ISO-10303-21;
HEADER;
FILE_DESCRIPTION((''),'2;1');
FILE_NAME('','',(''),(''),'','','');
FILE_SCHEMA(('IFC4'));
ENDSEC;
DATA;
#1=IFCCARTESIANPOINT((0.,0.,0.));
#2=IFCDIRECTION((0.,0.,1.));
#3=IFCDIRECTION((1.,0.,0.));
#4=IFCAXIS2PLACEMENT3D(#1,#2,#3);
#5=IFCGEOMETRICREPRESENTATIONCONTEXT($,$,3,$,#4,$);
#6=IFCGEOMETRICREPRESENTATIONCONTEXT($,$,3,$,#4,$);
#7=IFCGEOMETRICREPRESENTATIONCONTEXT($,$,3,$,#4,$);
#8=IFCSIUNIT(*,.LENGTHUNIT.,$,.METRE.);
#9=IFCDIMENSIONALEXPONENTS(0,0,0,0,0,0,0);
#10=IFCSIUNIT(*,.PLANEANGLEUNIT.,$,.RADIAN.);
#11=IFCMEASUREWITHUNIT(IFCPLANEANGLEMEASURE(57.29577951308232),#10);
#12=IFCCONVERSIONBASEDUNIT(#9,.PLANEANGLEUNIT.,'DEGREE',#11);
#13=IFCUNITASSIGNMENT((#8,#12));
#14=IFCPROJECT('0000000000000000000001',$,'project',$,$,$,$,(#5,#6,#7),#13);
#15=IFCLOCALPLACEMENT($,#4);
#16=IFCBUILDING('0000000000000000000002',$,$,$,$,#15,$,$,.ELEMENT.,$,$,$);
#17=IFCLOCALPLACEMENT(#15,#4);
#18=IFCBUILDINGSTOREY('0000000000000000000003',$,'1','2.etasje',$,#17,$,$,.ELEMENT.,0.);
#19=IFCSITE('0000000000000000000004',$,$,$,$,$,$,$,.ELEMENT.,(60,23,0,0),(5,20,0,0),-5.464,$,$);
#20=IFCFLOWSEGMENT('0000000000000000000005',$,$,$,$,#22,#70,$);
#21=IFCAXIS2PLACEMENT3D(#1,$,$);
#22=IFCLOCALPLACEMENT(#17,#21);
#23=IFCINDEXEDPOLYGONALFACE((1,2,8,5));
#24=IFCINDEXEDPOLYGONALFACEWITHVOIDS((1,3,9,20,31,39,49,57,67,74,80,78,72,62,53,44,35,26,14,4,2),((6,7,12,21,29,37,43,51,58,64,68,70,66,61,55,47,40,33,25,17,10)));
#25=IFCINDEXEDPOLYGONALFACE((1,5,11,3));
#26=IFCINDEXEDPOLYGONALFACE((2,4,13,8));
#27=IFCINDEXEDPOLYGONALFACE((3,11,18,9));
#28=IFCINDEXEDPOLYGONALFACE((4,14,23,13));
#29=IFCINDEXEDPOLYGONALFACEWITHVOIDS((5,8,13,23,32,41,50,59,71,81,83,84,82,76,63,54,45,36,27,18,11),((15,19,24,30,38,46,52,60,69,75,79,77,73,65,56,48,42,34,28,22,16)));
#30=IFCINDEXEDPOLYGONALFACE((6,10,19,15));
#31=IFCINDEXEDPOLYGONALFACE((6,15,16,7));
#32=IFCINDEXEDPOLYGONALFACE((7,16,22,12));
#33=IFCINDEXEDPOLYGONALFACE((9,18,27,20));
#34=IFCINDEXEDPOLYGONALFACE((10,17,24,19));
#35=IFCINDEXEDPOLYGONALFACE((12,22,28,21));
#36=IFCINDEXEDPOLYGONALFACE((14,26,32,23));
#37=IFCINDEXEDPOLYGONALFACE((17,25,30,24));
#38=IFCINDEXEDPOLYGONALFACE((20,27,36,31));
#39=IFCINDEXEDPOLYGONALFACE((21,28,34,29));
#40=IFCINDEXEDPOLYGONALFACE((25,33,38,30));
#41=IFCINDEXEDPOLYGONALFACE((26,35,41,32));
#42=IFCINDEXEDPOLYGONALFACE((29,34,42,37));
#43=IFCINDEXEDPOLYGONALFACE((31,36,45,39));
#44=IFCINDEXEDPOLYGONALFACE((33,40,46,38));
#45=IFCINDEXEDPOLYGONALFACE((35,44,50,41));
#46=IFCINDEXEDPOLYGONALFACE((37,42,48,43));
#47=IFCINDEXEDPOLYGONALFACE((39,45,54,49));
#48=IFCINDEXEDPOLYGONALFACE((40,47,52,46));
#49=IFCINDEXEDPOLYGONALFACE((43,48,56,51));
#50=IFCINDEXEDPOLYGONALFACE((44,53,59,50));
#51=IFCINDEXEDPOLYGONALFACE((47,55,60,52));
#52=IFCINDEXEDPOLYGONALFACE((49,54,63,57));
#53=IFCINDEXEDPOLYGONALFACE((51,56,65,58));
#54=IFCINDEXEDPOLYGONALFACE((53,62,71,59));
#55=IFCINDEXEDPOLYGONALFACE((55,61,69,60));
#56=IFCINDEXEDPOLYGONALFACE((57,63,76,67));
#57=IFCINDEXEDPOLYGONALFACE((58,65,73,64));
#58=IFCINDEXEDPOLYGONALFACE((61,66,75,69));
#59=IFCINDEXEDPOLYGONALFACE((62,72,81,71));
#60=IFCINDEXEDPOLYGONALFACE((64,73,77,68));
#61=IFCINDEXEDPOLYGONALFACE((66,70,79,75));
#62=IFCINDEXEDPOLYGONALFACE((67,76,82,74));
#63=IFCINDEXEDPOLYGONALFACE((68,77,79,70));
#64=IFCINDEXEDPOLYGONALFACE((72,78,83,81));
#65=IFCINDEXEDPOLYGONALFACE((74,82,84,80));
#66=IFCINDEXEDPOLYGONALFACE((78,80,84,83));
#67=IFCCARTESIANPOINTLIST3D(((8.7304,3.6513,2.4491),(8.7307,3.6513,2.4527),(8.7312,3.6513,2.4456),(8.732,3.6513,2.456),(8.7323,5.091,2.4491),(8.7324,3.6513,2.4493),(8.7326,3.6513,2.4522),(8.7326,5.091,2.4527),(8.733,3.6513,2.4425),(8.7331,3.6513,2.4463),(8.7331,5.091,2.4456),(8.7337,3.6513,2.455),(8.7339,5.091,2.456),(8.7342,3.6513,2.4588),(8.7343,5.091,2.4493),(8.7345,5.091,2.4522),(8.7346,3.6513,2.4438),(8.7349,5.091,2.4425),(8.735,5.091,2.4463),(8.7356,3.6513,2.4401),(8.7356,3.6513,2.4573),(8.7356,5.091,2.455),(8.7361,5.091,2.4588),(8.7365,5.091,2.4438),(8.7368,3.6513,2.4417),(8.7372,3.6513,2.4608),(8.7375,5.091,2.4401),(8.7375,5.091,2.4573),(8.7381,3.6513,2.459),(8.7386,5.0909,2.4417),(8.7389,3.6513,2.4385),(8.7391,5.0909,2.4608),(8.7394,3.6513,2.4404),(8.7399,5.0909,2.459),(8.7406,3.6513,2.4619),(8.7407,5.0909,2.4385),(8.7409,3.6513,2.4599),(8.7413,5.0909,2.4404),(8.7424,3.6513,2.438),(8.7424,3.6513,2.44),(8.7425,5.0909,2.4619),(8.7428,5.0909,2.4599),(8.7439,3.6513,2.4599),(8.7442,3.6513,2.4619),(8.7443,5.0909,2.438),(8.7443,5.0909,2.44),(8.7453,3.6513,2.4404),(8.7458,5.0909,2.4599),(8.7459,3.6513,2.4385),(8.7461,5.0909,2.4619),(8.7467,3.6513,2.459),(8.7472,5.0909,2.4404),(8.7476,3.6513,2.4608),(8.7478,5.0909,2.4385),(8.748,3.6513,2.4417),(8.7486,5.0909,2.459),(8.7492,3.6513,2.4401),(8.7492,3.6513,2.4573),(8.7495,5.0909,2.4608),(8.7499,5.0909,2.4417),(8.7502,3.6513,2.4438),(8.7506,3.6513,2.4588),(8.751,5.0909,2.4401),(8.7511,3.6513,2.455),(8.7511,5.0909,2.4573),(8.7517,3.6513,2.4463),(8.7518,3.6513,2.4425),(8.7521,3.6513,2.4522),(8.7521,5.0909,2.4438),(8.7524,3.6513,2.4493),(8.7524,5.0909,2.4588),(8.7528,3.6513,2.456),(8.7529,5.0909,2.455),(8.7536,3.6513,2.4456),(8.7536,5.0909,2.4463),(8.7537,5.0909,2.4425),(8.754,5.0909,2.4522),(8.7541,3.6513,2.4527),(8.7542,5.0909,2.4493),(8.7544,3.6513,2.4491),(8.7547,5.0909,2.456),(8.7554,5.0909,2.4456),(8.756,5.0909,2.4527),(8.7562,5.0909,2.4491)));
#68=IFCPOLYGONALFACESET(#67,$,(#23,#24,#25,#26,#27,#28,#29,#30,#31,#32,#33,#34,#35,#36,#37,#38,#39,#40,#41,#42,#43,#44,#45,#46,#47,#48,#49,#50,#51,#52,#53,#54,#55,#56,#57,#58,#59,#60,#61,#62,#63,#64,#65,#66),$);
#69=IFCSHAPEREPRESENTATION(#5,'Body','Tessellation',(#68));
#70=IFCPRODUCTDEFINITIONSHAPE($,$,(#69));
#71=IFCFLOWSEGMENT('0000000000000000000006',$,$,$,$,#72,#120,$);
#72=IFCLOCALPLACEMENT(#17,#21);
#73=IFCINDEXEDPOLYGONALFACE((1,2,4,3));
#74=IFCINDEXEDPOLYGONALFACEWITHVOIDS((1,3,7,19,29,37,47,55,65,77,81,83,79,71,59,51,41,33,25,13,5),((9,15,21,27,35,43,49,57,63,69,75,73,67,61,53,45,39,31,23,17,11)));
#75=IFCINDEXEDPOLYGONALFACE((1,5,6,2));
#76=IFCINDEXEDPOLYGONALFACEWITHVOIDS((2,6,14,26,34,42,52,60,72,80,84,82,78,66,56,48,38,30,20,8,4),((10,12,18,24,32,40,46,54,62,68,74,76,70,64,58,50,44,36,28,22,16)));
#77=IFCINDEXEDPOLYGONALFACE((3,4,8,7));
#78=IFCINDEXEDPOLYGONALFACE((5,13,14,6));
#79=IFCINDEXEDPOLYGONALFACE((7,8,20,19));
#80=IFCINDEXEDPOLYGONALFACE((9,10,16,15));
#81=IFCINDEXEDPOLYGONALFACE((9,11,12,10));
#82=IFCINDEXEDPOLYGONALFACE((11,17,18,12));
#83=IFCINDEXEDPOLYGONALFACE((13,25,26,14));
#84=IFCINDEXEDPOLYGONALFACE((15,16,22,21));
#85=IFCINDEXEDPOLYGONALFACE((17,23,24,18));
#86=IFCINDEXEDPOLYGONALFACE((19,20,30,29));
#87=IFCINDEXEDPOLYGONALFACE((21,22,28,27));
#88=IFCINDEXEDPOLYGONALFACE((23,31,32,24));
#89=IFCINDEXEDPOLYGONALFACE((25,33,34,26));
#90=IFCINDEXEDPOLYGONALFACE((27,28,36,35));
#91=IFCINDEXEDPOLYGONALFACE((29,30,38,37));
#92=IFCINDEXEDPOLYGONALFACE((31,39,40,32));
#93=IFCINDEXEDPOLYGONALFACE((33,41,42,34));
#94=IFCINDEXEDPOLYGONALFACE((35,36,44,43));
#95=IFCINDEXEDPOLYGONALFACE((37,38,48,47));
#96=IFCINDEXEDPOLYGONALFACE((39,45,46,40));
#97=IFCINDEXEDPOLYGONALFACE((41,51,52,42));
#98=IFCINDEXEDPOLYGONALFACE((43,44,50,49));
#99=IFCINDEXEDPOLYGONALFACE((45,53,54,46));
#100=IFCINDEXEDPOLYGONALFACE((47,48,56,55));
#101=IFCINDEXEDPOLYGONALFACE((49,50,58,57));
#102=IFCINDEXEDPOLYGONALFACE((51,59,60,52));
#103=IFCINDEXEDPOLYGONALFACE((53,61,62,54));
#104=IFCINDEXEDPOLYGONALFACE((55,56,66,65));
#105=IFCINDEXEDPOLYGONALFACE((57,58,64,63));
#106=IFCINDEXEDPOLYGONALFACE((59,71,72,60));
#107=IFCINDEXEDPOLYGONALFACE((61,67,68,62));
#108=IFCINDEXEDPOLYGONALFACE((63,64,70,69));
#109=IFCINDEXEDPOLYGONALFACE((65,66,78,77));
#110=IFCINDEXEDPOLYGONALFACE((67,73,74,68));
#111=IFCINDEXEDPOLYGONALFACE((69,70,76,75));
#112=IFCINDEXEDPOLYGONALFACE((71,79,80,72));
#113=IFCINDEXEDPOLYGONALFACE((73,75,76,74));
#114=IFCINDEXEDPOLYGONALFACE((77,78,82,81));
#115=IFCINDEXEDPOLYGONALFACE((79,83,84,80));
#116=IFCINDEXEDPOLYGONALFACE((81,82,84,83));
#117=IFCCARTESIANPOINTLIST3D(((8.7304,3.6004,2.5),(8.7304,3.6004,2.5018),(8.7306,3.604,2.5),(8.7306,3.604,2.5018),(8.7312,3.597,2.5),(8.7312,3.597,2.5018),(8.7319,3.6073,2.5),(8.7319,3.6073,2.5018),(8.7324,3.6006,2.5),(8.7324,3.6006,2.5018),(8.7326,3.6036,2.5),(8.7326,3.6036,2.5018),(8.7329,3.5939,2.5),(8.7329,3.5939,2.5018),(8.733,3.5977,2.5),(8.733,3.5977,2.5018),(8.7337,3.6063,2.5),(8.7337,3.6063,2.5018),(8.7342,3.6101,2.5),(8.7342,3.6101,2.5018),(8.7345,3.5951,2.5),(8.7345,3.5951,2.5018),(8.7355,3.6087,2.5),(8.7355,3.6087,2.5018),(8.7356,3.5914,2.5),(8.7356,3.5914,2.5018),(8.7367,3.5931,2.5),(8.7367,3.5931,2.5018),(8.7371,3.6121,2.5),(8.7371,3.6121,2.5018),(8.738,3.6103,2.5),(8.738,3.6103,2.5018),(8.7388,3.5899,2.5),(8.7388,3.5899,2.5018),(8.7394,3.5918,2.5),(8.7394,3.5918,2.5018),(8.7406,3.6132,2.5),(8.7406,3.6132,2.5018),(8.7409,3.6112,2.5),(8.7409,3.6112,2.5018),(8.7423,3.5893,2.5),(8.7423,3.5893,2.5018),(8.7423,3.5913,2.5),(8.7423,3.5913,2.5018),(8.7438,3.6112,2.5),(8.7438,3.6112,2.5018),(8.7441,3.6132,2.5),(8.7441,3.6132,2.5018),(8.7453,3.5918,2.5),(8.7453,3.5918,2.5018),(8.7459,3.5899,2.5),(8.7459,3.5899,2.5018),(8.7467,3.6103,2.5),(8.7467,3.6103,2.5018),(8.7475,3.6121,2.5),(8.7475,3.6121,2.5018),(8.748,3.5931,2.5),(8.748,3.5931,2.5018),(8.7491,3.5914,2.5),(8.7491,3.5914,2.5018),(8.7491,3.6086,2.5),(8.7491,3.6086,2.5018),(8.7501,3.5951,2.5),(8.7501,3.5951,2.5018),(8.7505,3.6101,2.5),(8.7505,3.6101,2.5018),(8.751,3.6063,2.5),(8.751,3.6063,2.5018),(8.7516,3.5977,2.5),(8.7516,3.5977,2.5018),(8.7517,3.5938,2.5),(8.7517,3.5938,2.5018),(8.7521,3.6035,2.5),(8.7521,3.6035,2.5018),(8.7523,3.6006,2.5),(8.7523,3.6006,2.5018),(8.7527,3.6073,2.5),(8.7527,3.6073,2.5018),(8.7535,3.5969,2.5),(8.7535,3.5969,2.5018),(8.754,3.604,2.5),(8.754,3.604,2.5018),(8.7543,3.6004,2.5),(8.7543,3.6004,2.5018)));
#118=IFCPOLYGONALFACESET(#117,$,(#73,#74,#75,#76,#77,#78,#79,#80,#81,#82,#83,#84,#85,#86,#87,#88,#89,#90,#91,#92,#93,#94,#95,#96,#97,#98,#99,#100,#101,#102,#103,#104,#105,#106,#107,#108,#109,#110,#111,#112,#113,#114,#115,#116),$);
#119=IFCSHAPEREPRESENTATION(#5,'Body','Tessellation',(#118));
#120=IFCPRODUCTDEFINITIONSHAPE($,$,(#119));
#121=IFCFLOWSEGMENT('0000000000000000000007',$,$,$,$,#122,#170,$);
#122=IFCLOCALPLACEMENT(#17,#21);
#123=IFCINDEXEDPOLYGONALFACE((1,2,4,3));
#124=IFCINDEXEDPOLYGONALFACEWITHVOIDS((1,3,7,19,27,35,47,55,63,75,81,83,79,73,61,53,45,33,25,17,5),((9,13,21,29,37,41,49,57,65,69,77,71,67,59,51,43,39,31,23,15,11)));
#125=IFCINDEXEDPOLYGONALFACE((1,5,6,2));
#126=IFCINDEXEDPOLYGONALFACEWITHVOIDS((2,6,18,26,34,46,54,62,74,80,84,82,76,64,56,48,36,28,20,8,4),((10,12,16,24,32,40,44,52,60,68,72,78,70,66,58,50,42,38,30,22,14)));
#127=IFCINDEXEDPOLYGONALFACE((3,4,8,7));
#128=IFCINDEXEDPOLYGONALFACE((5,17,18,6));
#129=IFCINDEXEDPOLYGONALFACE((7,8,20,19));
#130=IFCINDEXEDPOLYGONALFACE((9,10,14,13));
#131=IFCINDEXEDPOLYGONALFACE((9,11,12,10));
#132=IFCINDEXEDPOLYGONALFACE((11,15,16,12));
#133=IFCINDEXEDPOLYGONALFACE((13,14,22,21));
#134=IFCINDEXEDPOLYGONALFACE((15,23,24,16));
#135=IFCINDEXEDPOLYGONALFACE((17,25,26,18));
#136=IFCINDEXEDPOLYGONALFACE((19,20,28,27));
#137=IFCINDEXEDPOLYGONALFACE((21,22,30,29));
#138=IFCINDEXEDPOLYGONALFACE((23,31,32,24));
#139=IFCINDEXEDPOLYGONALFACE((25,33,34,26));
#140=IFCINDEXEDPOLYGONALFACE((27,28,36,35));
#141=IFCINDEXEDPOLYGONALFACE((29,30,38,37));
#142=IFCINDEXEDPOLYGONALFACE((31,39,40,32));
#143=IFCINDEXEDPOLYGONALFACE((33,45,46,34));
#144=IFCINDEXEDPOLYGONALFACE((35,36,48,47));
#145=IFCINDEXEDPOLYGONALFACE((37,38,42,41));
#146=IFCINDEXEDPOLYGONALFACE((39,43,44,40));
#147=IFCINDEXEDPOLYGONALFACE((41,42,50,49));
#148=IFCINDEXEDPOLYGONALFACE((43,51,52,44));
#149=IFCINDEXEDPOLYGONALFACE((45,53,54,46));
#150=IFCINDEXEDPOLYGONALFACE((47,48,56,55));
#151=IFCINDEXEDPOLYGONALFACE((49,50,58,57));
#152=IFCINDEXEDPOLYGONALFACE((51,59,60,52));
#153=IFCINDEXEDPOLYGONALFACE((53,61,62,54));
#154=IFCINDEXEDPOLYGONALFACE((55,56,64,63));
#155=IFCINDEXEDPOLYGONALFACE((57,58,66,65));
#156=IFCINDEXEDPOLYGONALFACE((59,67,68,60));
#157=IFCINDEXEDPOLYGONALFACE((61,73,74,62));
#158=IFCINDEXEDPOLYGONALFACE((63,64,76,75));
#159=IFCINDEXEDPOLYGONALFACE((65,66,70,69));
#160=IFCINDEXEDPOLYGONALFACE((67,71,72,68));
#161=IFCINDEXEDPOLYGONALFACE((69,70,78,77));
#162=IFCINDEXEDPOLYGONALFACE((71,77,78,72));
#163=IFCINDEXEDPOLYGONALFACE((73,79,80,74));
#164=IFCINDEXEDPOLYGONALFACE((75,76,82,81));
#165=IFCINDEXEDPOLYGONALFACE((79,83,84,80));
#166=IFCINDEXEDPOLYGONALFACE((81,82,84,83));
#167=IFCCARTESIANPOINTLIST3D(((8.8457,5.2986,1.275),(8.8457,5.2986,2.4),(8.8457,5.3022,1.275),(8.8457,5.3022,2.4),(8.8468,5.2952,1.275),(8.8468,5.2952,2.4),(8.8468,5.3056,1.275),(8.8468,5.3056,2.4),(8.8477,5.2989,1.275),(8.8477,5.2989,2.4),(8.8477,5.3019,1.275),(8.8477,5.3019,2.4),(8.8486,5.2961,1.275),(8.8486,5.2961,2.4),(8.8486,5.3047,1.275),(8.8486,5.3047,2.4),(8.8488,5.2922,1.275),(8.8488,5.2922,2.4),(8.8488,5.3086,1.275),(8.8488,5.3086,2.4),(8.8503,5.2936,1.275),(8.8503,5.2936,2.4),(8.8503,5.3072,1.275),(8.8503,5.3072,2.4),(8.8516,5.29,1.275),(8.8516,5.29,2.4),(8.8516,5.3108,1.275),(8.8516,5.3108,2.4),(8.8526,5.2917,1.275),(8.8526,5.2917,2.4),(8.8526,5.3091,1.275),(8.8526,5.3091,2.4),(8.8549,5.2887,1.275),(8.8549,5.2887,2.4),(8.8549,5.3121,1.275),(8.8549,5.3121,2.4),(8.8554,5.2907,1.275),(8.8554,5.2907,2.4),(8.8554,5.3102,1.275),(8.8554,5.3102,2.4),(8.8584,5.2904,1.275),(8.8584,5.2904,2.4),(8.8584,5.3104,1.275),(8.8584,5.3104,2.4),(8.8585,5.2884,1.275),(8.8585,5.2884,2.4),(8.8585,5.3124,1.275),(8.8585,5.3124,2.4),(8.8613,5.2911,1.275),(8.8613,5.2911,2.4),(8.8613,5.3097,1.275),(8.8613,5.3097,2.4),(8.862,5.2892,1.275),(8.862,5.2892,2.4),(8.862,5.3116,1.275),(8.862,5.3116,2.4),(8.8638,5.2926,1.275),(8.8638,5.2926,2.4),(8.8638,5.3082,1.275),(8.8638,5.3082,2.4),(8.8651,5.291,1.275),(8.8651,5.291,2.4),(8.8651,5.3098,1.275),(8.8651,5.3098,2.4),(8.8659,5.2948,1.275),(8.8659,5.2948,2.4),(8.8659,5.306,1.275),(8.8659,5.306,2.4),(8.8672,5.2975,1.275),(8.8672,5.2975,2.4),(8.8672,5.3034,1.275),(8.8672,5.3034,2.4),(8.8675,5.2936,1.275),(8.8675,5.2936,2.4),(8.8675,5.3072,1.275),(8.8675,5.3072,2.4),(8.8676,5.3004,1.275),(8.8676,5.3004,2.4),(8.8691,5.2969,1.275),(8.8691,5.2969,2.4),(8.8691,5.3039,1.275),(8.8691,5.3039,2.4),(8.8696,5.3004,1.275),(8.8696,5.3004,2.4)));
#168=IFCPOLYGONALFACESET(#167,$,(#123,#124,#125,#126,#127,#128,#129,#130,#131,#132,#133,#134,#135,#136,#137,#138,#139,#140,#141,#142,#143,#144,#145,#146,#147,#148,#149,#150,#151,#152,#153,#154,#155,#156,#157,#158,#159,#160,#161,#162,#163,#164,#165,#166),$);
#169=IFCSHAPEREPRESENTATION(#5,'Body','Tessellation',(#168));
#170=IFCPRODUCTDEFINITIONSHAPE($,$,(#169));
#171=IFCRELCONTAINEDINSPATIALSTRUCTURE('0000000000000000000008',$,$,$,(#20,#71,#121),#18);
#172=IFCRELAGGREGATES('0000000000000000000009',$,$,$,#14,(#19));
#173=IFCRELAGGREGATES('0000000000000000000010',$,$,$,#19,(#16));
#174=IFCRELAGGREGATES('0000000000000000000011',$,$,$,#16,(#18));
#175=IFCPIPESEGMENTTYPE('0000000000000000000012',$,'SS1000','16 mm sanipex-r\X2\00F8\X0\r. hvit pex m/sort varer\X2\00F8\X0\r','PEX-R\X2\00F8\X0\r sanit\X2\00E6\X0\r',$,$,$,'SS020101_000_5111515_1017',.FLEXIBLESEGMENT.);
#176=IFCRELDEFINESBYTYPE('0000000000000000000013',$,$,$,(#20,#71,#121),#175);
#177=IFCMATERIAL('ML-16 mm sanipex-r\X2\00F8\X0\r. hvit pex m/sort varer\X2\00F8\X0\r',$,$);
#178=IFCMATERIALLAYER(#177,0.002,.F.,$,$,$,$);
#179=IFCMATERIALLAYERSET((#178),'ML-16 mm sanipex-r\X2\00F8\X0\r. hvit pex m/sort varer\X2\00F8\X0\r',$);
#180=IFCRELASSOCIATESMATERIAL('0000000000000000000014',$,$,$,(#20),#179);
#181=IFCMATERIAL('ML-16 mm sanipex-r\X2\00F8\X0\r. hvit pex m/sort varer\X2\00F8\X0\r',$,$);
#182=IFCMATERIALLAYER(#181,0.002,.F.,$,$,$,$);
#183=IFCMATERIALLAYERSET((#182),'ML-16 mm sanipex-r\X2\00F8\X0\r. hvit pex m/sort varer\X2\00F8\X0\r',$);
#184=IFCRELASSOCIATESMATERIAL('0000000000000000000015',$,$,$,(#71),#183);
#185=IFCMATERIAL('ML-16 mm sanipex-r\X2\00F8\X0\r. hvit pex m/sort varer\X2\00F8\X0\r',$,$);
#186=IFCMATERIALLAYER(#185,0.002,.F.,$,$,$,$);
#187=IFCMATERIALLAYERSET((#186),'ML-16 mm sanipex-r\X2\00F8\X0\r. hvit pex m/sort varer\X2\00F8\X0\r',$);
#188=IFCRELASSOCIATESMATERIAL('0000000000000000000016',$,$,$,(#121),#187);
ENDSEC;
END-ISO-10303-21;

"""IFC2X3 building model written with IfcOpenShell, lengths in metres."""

from ifc_helpers import new_model, entity, si_unit, converted_unit, frame, origin_with_axes, origin_2d_with_axis, place, context, project, spatial, hollow_circle, extrude, material, layer, layer_set, layer_usage, type_object, element, save


model = new_model("IFC2X3")

# Units and contexts
context_of_model_1 = context(None, 3, world=origin_with_axes())
context_of_model_2 = context(None, 3, world=origin_with_axes())
context_of_model_3 = context(None, 3, world=origin_with_axes())
ifc_project = project(units=[si_unit("LENGTHUNIT", "METRE"), converted_unit("PLANEANGLEUNIT", "DEGREE", entity("IfcPlaneAngleMeasure", 57.29577951308232), si_unit("PLANEANGLEUNIT", "RADIAN"), dimensions=[0, 0, 0, 0, 0, 0, 0])], contexts=[context_of_model_1, context_of_model_2, context_of_model_3])

# Site, building, storey
site = spatial("IfcSite", under=ifc_project, CompositionType="ELEMENT", RefLatitude=(60, 23, 0, 0), RefLongitude=(5, 20, 0, 0), RefElevation=-5.464)
building_placement = place(None, origin_with_axes())
building = spatial("IfcBuilding", under=site, at=building_placement, CompositionType="ELEMENT")
storey_placement = place(building_placement, origin_with_axes())
storey = spatial("IfcBuildingStorey", under=building, at=storey_placement, Name="1", Description="2.etasje", CompositionType="ELEMENT", Elevation=0.0)

# Flow segments
pipe_segment_type_1 = type_object("IfcPipeSegmentType", Name="SS1000", Description="16 mm sanipex-rør. hvit pex m/sort varerør", ApplicableOccurrence="PEX-Rør sanitær", ElementType="SS020101_000_5111515_1017", PredefinedType="FLEXIBLESEGMENT")
ifc_material_1 = material(Name="ML-16 mm sanipex-rør. hvit pex m/sort varerør")
ifc_layer_1 = layer(ifc_material_1, 0.002, ventilated=False)
ifc_layer_set_1 = layer_set([ifc_layer_1], Name="ML-16 mm sanipex-rør. hvit pex m/sort varerør")
ifc_layer_usage_1 = layer_usage(ifc_layer_set_1, "AXIS2", "POSITIVE", 0.0)
flow_segment_1_placement = place(storey_placement, frame((8.7443, 5.0909, 2.45), z_axis=(-0.001306, -0.999999, 0.0), x_axis=(0.0, 0.0, -1.0)))
element("IfcFlowSegment", 1, at=flow_segment_1_placement, inside=storey, type_object=pipe_segment_type_1, material=ifc_layer_usage_1, context=context_of_model_1, shape_type="SweptSolid", body=[
    extrude(hollow_circle(Radius=0.012, WallThickness=0.002, at=origin_2d_with_axis()), origin_with_axes(), (0.0, 0.0, 1.0), 1.4396),
])
ifc_material_2 = material(Name="ML-16 mm sanipex-rør. hvit pex m/sort varerør")
ifc_layer_2 = layer(ifc_material_2, 0.002, ventilated=False)
ifc_layer_set_2 = layer_set([ifc_layer_2], Name="ML-16 mm sanipex-rør. hvit pex m/sort varerør")
ifc_layer_usage_2 = layer_usage(ifc_layer_set_2, "AXIS2", "POSITIVE", 0.0)
flow_segment_2_placement = place(storey_placement, frame((8.7423, 3.6013, 2.5), z_axis=(0.0, 0.0, 1.0), x_axis=(-0.001306, -0.999999, 0.0)))
element("IfcFlowSegment", 2, at=flow_segment_2_placement, inside=storey, type_object=pipe_segment_type_1, material=ifc_layer_usage_2, context=context_of_model_1, shape_type="SweptSolid", body=[
    extrude(hollow_circle(Radius=0.012, WallThickness=0.002, at=origin_2d_with_axis()), origin_with_axes(), (0.0, 0.0, 1.0), 0.0018),
])
ifc_material_3 = material(Name="ML-16 mm sanipex-rør. hvit pex m/sort varerør")
ifc_layer_3 = layer(ifc_material_3, 0.002, ventilated=False)
ifc_layer_set_3 = layer_set([ifc_layer_3], Name="ML-16 mm sanipex-rør. hvit pex m/sort varerør")
ifc_layer_usage_3 = layer_usage(ifc_layer_set_3, "AXIS2", "POSITIVE", 0.0)
flow_segment_3_placement = place(storey_placement, frame((8.8576, 5.3004, 1.275), z_axis=(0.0, 0.0, 1.0), x_axis=(1.0, 0.0, 0.0)))
element("IfcFlowSegment", 3, at=flow_segment_3_placement, inside=storey, type_object=pipe_segment_type_1, material=ifc_layer_usage_3, context=context_of_model_1, shape_type="SweptSolid", body=[
    extrude(hollow_circle(Radius=0.012, WallThickness=0.002, at=origin_2d_with_axis()), origin_with_axes(), (0.0, 0.0, 1.0), 1.125),
])

save(model, "model.ifc")
